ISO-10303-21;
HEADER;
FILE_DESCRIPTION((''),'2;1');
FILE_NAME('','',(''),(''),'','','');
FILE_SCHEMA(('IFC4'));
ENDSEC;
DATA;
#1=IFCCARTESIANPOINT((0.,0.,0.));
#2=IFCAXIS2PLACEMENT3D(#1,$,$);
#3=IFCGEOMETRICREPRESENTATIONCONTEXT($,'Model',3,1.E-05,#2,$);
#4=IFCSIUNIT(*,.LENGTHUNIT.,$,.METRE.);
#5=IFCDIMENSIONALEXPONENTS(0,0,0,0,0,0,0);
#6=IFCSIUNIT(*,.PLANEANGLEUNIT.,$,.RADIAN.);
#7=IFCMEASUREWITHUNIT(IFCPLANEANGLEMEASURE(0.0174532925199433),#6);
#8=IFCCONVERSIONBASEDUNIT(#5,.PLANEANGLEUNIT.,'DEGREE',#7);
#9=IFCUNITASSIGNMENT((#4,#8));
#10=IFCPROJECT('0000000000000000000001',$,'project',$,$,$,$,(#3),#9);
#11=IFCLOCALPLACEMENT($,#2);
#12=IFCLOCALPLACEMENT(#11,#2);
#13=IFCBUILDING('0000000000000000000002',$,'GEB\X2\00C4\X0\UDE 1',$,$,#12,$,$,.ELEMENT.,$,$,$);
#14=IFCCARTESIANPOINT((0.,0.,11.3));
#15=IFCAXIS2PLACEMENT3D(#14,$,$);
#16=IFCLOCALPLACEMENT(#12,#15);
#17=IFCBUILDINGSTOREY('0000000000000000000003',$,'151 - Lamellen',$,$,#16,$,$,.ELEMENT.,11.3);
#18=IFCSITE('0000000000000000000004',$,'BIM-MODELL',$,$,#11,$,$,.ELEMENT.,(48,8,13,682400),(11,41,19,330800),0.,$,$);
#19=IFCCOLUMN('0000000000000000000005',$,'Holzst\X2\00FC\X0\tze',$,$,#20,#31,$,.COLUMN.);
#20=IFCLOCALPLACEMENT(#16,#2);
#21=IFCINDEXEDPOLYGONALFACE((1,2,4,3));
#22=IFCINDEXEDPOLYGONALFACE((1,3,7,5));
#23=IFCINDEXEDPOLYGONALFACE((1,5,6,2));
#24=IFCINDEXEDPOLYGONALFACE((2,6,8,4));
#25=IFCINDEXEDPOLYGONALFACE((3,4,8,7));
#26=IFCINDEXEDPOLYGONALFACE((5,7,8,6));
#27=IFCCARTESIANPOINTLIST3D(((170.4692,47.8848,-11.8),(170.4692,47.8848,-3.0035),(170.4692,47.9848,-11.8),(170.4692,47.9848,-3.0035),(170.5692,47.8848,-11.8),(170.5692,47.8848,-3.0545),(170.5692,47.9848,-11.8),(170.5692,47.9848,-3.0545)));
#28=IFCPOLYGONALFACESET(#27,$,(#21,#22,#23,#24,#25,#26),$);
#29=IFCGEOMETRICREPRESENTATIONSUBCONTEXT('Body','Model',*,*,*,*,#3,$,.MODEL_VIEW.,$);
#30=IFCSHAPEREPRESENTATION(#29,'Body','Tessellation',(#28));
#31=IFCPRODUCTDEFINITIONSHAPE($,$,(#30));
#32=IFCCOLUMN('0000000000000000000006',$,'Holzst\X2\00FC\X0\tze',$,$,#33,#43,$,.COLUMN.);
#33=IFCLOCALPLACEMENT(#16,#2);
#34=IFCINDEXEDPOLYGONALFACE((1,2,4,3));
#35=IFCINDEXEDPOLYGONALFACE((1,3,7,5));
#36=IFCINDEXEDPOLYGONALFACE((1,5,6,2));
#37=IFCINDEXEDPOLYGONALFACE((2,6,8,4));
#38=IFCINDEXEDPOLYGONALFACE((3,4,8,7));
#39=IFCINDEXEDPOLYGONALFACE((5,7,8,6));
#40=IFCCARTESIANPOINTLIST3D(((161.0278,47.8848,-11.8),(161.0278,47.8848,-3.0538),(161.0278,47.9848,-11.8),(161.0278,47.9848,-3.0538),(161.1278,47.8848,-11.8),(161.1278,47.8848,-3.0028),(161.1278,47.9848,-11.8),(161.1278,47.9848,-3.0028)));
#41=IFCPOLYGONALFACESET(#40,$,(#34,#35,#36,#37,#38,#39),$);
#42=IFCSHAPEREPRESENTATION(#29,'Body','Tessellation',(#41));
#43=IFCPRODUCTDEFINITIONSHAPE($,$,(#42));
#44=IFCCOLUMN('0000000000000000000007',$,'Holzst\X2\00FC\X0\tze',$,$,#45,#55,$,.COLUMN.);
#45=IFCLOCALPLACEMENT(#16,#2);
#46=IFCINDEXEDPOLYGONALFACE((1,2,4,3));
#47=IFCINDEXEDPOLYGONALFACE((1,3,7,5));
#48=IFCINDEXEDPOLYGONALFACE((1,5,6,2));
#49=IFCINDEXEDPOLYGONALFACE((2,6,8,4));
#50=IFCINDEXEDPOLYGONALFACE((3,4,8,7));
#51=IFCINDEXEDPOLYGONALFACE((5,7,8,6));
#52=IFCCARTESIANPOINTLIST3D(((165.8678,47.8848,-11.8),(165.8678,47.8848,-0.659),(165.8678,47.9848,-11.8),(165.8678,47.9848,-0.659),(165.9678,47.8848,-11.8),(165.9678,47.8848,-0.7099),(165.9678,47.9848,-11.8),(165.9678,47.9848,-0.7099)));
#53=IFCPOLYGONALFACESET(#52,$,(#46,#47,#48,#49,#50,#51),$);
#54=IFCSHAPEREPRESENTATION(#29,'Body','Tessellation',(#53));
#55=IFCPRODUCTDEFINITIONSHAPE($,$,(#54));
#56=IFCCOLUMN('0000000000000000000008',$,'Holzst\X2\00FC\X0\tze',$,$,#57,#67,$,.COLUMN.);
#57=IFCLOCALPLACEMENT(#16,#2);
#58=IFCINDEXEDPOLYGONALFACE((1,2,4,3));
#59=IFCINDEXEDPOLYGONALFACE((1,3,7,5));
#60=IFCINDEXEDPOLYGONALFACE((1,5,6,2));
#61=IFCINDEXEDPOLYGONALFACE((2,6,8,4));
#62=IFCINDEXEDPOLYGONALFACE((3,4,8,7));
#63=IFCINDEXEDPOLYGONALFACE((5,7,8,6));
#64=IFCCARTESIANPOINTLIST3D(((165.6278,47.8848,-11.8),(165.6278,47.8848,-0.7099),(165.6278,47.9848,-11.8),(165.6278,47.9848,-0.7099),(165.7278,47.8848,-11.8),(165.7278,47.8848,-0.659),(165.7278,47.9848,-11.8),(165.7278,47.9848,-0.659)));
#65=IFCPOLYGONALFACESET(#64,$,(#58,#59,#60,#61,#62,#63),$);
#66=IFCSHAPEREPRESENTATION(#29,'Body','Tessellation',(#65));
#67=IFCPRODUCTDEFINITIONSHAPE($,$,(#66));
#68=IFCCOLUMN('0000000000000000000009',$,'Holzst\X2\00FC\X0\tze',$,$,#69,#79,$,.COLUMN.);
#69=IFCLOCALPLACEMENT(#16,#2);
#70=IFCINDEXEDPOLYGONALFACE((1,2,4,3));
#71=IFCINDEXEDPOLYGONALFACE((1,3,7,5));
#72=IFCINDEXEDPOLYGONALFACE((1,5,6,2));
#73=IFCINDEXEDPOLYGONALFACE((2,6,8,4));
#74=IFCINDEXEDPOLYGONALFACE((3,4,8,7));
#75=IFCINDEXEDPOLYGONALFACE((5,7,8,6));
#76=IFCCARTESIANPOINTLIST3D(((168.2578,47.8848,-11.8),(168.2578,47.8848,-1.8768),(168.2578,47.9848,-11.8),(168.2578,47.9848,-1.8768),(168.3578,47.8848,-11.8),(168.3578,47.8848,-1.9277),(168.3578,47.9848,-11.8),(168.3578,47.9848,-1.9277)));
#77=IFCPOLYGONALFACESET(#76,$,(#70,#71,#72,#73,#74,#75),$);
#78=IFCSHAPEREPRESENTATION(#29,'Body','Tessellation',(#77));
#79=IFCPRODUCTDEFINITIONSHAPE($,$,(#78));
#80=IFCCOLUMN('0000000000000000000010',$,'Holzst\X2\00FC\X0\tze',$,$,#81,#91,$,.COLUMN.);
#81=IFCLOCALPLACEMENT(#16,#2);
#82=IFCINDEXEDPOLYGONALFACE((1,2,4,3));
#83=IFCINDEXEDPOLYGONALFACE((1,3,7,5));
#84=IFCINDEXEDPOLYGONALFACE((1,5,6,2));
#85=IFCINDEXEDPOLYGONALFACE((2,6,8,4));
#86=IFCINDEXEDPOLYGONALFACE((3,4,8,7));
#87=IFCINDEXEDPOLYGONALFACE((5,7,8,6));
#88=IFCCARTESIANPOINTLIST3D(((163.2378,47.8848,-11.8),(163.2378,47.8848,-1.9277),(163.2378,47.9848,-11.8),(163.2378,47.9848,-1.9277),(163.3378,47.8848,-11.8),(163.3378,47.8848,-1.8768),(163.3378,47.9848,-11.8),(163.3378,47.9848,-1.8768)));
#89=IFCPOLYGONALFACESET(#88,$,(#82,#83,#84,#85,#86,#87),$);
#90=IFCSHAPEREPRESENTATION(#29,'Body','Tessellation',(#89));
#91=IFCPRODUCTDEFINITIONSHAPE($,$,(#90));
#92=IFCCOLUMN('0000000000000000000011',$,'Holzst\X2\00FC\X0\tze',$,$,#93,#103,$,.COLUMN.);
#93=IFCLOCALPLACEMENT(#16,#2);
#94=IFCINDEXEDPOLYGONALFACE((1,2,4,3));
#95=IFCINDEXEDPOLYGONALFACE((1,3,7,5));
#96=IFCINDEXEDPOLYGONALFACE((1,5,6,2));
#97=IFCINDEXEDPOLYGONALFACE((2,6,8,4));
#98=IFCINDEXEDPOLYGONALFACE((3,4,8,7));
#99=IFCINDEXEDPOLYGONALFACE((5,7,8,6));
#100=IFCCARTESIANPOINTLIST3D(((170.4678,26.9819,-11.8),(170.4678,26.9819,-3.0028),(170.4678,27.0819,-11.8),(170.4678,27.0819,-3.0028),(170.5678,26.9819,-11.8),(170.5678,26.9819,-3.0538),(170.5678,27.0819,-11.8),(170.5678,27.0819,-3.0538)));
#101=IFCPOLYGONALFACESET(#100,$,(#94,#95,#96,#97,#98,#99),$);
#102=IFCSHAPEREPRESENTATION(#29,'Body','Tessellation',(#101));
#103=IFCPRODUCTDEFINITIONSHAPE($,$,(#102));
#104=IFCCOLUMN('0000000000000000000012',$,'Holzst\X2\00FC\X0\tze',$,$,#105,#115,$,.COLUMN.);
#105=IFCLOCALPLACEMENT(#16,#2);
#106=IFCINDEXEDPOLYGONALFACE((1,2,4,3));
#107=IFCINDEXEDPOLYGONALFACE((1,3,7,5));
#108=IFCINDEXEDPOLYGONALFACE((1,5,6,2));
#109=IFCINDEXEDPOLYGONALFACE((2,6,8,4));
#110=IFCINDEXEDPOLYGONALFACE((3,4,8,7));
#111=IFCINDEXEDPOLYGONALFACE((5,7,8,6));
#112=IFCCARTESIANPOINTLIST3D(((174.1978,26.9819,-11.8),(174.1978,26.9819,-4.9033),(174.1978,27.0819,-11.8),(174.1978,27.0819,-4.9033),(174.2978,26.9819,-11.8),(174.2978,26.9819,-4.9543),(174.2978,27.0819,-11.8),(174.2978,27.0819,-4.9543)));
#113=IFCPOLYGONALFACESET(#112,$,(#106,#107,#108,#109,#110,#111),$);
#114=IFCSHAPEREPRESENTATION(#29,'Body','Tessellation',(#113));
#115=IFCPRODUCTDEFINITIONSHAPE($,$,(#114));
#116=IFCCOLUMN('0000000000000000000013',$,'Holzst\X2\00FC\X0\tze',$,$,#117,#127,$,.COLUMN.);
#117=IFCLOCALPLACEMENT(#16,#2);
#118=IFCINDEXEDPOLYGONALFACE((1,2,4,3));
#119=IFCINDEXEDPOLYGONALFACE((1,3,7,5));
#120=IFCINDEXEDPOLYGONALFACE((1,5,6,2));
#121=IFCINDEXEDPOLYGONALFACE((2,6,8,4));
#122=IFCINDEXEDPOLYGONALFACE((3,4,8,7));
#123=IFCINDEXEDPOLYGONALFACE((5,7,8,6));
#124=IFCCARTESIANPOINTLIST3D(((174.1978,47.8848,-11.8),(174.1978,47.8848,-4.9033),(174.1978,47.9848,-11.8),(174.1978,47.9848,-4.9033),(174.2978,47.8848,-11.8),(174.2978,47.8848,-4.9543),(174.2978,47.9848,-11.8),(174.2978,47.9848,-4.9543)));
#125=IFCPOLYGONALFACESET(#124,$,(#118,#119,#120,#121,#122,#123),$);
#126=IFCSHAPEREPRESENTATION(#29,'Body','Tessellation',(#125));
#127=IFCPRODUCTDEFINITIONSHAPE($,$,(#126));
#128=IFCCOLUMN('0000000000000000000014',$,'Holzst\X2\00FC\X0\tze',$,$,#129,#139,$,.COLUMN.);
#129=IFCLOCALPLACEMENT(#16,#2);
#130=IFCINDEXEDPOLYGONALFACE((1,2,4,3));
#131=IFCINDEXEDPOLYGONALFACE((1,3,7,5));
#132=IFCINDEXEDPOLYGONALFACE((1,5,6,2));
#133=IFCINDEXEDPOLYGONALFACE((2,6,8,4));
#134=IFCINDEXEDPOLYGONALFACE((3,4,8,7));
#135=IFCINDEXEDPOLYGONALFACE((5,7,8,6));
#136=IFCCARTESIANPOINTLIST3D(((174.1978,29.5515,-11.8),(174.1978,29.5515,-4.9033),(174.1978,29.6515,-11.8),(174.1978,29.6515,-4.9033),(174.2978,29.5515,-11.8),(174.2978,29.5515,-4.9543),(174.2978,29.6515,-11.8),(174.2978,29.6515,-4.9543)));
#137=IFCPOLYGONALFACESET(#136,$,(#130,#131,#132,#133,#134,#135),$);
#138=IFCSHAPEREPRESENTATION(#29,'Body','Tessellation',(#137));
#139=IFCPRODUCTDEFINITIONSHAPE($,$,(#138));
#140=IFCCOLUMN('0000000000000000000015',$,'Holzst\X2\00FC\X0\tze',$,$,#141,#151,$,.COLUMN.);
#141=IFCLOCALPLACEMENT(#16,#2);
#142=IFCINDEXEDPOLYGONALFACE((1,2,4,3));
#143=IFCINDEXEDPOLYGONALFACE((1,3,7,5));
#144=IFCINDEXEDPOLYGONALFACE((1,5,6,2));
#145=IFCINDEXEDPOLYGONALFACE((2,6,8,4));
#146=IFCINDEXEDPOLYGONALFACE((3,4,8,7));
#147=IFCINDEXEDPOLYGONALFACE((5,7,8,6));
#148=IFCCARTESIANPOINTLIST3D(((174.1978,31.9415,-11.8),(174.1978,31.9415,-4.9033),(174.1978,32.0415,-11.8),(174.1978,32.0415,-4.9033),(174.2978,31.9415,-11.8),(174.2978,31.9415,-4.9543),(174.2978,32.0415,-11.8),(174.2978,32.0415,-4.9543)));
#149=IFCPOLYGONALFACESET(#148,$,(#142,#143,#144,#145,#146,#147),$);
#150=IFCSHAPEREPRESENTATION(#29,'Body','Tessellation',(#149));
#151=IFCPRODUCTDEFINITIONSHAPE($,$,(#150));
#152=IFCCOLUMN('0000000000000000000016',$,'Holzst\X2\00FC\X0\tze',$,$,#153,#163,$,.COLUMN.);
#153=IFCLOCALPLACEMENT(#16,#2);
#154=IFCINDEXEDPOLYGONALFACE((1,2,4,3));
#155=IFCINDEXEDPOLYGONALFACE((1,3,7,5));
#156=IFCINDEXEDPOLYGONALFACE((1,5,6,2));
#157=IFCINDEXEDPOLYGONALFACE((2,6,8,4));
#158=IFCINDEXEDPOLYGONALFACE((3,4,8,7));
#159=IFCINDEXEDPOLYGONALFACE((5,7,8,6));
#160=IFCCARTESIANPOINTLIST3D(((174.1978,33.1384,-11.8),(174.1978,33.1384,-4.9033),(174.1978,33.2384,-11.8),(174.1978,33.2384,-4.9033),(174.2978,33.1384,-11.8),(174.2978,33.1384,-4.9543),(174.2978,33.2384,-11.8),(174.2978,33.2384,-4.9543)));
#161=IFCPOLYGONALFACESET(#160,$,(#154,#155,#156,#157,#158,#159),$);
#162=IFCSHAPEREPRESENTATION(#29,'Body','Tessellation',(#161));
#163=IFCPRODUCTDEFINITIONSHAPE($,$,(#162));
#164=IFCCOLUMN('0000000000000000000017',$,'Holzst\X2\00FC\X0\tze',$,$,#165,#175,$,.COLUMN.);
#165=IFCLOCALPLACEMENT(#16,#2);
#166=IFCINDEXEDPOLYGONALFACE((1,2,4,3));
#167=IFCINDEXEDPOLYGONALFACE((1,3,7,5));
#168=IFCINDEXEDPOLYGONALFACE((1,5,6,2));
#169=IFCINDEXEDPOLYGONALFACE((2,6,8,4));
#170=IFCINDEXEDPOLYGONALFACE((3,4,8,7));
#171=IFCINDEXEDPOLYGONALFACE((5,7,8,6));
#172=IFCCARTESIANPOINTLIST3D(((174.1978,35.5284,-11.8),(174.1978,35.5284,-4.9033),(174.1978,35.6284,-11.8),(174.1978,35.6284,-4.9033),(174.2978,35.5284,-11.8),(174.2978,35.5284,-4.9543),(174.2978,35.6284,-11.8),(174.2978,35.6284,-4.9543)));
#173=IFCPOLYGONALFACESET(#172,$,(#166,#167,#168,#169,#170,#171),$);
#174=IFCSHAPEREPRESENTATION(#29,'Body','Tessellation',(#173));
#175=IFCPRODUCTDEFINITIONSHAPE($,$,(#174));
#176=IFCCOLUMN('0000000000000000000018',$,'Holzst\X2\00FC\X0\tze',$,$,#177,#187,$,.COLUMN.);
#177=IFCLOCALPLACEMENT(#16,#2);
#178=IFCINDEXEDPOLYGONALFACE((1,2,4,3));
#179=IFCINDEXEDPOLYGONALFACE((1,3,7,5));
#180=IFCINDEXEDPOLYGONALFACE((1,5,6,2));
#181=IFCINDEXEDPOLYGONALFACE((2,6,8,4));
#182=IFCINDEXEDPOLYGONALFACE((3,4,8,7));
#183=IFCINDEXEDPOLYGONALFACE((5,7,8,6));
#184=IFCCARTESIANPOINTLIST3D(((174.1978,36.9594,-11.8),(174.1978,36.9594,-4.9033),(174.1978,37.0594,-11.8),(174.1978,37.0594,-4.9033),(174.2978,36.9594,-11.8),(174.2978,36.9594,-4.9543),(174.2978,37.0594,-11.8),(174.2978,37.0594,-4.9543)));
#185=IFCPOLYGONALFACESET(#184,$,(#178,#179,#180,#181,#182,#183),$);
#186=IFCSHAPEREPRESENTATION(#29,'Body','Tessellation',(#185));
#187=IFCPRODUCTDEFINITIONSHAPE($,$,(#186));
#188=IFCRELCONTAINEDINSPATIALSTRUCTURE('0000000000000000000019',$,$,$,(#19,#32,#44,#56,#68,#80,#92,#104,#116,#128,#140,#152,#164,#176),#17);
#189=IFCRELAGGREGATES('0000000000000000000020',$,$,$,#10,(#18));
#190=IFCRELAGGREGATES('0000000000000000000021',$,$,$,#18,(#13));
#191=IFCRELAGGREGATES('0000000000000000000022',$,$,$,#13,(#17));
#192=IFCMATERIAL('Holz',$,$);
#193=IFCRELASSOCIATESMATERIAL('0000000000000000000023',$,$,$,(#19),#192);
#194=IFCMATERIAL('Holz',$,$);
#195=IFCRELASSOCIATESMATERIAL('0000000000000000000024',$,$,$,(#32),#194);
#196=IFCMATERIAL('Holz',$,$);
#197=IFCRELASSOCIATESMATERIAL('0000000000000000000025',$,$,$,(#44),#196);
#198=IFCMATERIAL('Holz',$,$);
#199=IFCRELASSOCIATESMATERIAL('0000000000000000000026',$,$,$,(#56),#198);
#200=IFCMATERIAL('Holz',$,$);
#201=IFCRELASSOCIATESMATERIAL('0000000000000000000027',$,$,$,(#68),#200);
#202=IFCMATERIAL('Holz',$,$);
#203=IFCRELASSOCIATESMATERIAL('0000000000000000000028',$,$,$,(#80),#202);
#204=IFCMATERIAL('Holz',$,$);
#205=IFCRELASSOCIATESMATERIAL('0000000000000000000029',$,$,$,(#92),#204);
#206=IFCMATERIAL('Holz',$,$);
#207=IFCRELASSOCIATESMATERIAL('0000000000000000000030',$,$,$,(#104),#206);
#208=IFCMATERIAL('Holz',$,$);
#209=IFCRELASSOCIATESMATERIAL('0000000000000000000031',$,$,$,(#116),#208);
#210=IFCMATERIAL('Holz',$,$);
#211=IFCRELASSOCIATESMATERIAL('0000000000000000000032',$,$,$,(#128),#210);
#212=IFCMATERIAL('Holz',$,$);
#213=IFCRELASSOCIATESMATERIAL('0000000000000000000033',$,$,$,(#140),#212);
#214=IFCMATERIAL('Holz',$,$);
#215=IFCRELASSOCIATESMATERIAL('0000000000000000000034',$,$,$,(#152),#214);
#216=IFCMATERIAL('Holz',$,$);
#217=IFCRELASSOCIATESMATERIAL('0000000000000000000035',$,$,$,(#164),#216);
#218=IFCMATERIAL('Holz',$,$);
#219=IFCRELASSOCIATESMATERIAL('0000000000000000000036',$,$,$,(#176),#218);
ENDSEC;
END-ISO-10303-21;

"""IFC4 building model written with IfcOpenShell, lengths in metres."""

from ifc_helpers import new_model, entity, si_unit, converted_unit, frame, frame_2d, origin, origin_with_axes, place, context, subcontext, project, spatial, rectangle, extrude, clip, halfspace, material, element, save


model = new_model("IFC4")

# Units and contexts
model_context = context("Model", 3, precision=1e-05, world=origin())
body_context = subcontext(model_context, "Body", "Model", "MODEL_VIEW")
ifc_project = project(units=[si_unit("LENGTHUNIT", "METRE"), converted_unit("PLANEANGLEUNIT", "DEGREE", entity("IfcPlaneAngleMeasure", 0.0174532925199433), si_unit("PLANEANGLEUNIT", "RADIAN"), dimensions=[0, 0, 0, 0, 0, 0, 0])], contexts=[model_context])

# Site, building, storey
site_placement = place(None, origin())
site = spatial("IfcSite", under=ifc_project, at=site_placement, Name="BIM-MODELL", CompositionType="ELEMENT", RefLatitude=(48, 8, 13, 682400), RefLongitude=(11, 41, 19, 330800), RefElevation=0.0)
building_placement = place(site_placement, origin())
building = spatial("IfcBuilding", under=site, at=building_placement, Name="GEBÄUDE 1", CompositionType="ELEMENT")
storey_placement = place(building_placement, frame((0.0, 0.0, 11.3)))
storey = spatial("IfcBuildingStorey", under=building, at=storey_placement, Name="151 - Lamellen", CompositionType="ELEMENT", Elevation=11.3)

# Columns
ifc_material_1 = material(Name="Holz")
column_1_placement = place(storey_placement, frame((170.5692, 47.8848, -11.8)))
element("IfcColumn", 1, at=column_1_placement, inside=storey, material=ifc_material_1, Name="Holzstütze", PredefinedType="COLUMN", context=body_context, shape_type="Clipping", body=[
    clip(extrude(rectangle(XDim=0.1, YDim=0.1, at=frame_2d((-0.05, 0.05), x_axis=(0.0, 1.0))), origin_with_axes(), (0.0, 0.0, 1.0), 8.7965), halfspace(frame((-0.05, 0.05, 8.771), z_axis=(-0.45399, 0.0, -0.891007), x_axis=(0.0, 1.0, 0.0)), True)),
])
ifc_material_2 = material(Name="Holz")
column_2_placement = place(storey_placement, frame((161.1278, 47.8848, -11.8)))
element("IfcColumn", 2, at=column_2_placement, inside=storey, material=ifc_material_2, Name="Holzstütze", PredefinedType="COLUMN", context=body_context, shape_type="Clipping", body=[
    clip(extrude(rectangle(XDim=0.1, YDim=0.1, at=frame_2d((-0.05, 0.05), x_axis=(0.0, 1.0))), origin_with_axes(), (0.0, 0.0, 1.0), 8.7972), halfspace(frame((-0.05, 0.05, 8.7717), z_axis=(0.45399, 0.0, -0.891007), x_axis=(0.0, 1.0, 0.0)), True)),
])
ifc_material_3 = material(Name="Holz")
column_3_placement = place(storey_placement, frame((165.9678, 47.8848, -11.8)))
element("IfcColumn", 3, at=column_3_placement, inside=storey, material=ifc_material_3, Name="Holzstütze", PredefinedType="COLUMN", context=body_context, shape_type="Clipping", body=[
    clip(extrude(rectangle(XDim=0.1, YDim=0.1, at=frame_2d((-0.05, 0.05), x_axis=(0.0, 1.0))), origin_with_axes(), (0.0, 0.0, 1.0), 11.141), halfspace(frame((-0.05, 0.05, 11.1155), z_axis=(-0.45399, 0.0, -0.891007), x_axis=(0.0, 1.0, 0.0)), True)),
])
ifc_material_4 = material(Name="Holz")
column_4_placement = place(storey_placement, frame((165.7278, 47.8848, -11.8)))
element("IfcColumn", 4, at=column_4_placement, inside=storey, material=ifc_material_4, Name="Holzstütze", PredefinedType="COLUMN", context=body_context, shape_type="Clipping", body=[
    clip(extrude(rectangle(XDim=0.1, YDim=0.1, at=frame_2d((-0.05, 0.05), x_axis=(0.0, 1.0))), origin_with_axes(), (0.0, 0.0, 1.0), 11.141), halfspace(frame((-0.05, 0.05, 11.1155), z_axis=(0.45399, 0.0, -0.891007), x_axis=(0.0, 1.0, 0.0)), True)),
])
ifc_material_5 = material(Name="Holz")
column_5_placement = place(storey_placement, frame((168.3578, 47.8848, -11.8)))
element("IfcColumn", 5, at=column_5_placement, inside=storey, material=ifc_material_5, Name="Holzstütze", PredefinedType="COLUMN", context=body_context, shape_type="Clipping", body=[
    clip(extrude(rectangle(XDim=0.1, YDim=0.1, at=frame_2d((-0.05, 0.05), x_axis=(0.0, 1.0))), origin_with_axes(), (0.0, 0.0, 1.0), 9.9232), halfspace(frame((-0.05, 0.05, 9.8978), z_axis=(-0.45399, 0.0, -0.891007), x_axis=(0.0, 1.0, 0.0)), True)),
])
ifc_material_6 = material(Name="Holz")
column_6_placement = place(storey_placement, frame((163.3378, 47.8848, -11.8)))
element("IfcColumn", 6, at=column_6_placement, inside=storey, material=ifc_material_6, Name="Holzstütze", PredefinedType="COLUMN", context=body_context, shape_type="Clipping", body=[
    clip(extrude(rectangle(XDim=0.1, YDim=0.1, at=frame_2d((-0.05, 0.05), x_axis=(0.0, 1.0))), origin_with_axes(), (0.0, 0.0, 1.0), 9.9232), halfspace(frame((-0.05, 0.05, 9.8978), z_axis=(0.45399, 0.0, -0.891007), x_axis=(0.0, 1.0, 0.0)), True)),
])
ifc_material_7 = material(Name="Holz")
column_7_placement = place(storey_placement, frame((170.5678, 26.9819, -11.8)))
element("IfcColumn", 7, at=column_7_placement, inside=storey, material=ifc_material_7, Name="Holzstütze", PredefinedType="COLUMN", context=body_context, shape_type="Clipping", body=[
    clip(extrude(rectangle(XDim=0.1, YDim=0.1, at=frame_2d((-0.05, 0.05), x_axis=(0.0, 1.0))), origin_with_axes(), (0.0, 0.0, 1.0), 8.7972), halfspace(frame((-0.05, 0.05, 8.7717), z_axis=(-0.45399, 0.0, -0.891007), x_axis=(0.0, -1.0, 0.0)), True)),
])
ifc_material_8 = material(Name="Holz")
column_8_placement = place(storey_placement, frame((174.2978, 26.9819, -11.8)))
element("IfcColumn", 8, at=column_8_placement, inside=storey, material=ifc_material_8, Name="Holzstütze", PredefinedType="COLUMN", context=body_context, shape_type="Clipping", body=[
    clip(extrude(rectangle(XDim=0.1, YDim=0.1, at=frame_2d((-0.05, 0.05), x_axis=(0.0, 1.0))), origin_with_axes(), (0.0, 0.0, 1.0), 6.8967), halfspace(frame((-0.05, 0.05, 6.8712), z_axis=(-0.45399, 0.0, -0.891007), x_axis=(0.0, -1.0, 0.0)), True)),
])
ifc_material_9 = material(Name="Holz")
column_9_placement = place(storey_placement, frame((174.2978, 47.8848, -11.8)))
element("IfcColumn", 9, at=column_9_placement, inside=storey, material=ifc_material_9, Name="Holzstütze", PredefinedType="COLUMN", context=body_context, shape_type="Clipping", body=[
    clip(extrude(rectangle(XDim=0.1, YDim=0.1, at=frame_2d((-0.05, 0.05), x_axis=(0.0, 1.0))), origin_with_axes(), (0.0, 0.0, 1.0), 6.8967), halfspace(frame((-0.05, 0.05, 6.8712), z_axis=(-0.45399, 0.0, -0.891007), x_axis=(0.891007, 0.0, -0.45399)), True)),
])
ifc_material_10 = material(Name="Holz")
column_10_placement = place(storey_placement, frame((174.2978, 29.5515, -11.8)))
element("IfcColumn", 10, at=column_10_placement, inside=storey, material=ifc_material_10, Name="Holzstütze", PredefinedType="COLUMN", context=body_context, shape_type="Clipping", body=[
    clip(extrude(rectangle(XDim=0.1, YDim=0.1, at=frame_2d((-0.05, 0.05), x_axis=(0.0, 1.0))), origin_with_axes(), (0.0, 0.0, 1.0), 6.8967), halfspace(frame((-0.05, 0.05, 6.8712), z_axis=(-0.45399, 0.0, -0.891007), x_axis=(0.891007, 0.0, -0.45399)), True)),
])
ifc_material_11 = material(Name="Holz")
column_11_placement = place(storey_placement, frame((174.2978, 31.9415, -11.8)))
element("IfcColumn", 11, at=column_11_placement, inside=storey, material=ifc_material_11, Name="Holzstütze", PredefinedType="COLUMN", context=body_context, shape_type="Clipping", body=[
    clip(extrude(rectangle(XDim=0.1, YDim=0.1, at=frame_2d((-0.05, 0.05), x_axis=(0.0, 1.0))), origin_with_axes(), (0.0, 0.0, 1.0), 6.8967), halfspace(frame((-0.05, 0.05, 6.8712), z_axis=(-0.45399, 0.0, -0.891007), x_axis=(0.891007, 0.0, -0.45399)), True)),
])
ifc_material_12 = material(Name="Holz")
column_12_placement = place(storey_placement, frame((174.2978, 33.1384, -11.8)))
element("IfcColumn", 12, at=column_12_placement, inside=storey, material=ifc_material_12, Name="Holzstütze", PredefinedType="COLUMN", context=body_context, shape_type="Clipping", body=[
    clip(extrude(rectangle(XDim=0.1, YDim=0.1, at=frame_2d((-0.05, 0.05), x_axis=(0.0, 1.0))), origin_with_axes(), (0.0, 0.0, 1.0), 6.8967), halfspace(frame((-0.05, 0.05, 6.8712), z_axis=(-0.45399, 0.0, -0.891007), x_axis=(0.891007, 0.0, -0.45399)), True)),
])
ifc_material_13 = material(Name="Holz")
column_13_placement = place(storey_placement, frame((174.2978, 35.5284, -11.8)))
element("IfcColumn", 13, at=column_13_placement, inside=storey, material=ifc_material_13, Name="Holzstütze", PredefinedType="COLUMN", context=body_context, shape_type="Clipping", body=[
    clip(extrude(rectangle(XDim=0.1, YDim=0.1, at=frame_2d((-0.05, 0.05), x_axis=(0.0, 1.0))), origin_with_axes(), (0.0, 0.0, 1.0), 6.8967), halfspace(frame((-0.05, 0.05, 6.8712), z_axis=(-0.45399, 0.0, -0.891007), x_axis=(0.891007, 0.0, -0.45399)), True)),
])
ifc_material_14 = material(Name="Holz")
column_14_placement = place(storey_placement, frame((174.2978, 36.9594, -11.8)))
element("IfcColumn", 14, at=column_14_placement, inside=storey, material=ifc_material_14, Name="Holzstütze", PredefinedType="COLUMN", context=body_context, shape_type="Clipping", body=[
    clip(extrude(rectangle(XDim=0.1, YDim=0.1, at=frame_2d((-0.05, 0.05), x_axis=(0.0, 1.0))), origin_with_axes(), (0.0, 0.0, 1.0), 6.8967), halfspace(frame((-0.05, 0.05, 6.8712), z_axis=(-0.45399, 0.0, -0.891007), x_axis=(0.891007, 0.0, -0.45399)), True)),
])

save(model, "model.ifc")
